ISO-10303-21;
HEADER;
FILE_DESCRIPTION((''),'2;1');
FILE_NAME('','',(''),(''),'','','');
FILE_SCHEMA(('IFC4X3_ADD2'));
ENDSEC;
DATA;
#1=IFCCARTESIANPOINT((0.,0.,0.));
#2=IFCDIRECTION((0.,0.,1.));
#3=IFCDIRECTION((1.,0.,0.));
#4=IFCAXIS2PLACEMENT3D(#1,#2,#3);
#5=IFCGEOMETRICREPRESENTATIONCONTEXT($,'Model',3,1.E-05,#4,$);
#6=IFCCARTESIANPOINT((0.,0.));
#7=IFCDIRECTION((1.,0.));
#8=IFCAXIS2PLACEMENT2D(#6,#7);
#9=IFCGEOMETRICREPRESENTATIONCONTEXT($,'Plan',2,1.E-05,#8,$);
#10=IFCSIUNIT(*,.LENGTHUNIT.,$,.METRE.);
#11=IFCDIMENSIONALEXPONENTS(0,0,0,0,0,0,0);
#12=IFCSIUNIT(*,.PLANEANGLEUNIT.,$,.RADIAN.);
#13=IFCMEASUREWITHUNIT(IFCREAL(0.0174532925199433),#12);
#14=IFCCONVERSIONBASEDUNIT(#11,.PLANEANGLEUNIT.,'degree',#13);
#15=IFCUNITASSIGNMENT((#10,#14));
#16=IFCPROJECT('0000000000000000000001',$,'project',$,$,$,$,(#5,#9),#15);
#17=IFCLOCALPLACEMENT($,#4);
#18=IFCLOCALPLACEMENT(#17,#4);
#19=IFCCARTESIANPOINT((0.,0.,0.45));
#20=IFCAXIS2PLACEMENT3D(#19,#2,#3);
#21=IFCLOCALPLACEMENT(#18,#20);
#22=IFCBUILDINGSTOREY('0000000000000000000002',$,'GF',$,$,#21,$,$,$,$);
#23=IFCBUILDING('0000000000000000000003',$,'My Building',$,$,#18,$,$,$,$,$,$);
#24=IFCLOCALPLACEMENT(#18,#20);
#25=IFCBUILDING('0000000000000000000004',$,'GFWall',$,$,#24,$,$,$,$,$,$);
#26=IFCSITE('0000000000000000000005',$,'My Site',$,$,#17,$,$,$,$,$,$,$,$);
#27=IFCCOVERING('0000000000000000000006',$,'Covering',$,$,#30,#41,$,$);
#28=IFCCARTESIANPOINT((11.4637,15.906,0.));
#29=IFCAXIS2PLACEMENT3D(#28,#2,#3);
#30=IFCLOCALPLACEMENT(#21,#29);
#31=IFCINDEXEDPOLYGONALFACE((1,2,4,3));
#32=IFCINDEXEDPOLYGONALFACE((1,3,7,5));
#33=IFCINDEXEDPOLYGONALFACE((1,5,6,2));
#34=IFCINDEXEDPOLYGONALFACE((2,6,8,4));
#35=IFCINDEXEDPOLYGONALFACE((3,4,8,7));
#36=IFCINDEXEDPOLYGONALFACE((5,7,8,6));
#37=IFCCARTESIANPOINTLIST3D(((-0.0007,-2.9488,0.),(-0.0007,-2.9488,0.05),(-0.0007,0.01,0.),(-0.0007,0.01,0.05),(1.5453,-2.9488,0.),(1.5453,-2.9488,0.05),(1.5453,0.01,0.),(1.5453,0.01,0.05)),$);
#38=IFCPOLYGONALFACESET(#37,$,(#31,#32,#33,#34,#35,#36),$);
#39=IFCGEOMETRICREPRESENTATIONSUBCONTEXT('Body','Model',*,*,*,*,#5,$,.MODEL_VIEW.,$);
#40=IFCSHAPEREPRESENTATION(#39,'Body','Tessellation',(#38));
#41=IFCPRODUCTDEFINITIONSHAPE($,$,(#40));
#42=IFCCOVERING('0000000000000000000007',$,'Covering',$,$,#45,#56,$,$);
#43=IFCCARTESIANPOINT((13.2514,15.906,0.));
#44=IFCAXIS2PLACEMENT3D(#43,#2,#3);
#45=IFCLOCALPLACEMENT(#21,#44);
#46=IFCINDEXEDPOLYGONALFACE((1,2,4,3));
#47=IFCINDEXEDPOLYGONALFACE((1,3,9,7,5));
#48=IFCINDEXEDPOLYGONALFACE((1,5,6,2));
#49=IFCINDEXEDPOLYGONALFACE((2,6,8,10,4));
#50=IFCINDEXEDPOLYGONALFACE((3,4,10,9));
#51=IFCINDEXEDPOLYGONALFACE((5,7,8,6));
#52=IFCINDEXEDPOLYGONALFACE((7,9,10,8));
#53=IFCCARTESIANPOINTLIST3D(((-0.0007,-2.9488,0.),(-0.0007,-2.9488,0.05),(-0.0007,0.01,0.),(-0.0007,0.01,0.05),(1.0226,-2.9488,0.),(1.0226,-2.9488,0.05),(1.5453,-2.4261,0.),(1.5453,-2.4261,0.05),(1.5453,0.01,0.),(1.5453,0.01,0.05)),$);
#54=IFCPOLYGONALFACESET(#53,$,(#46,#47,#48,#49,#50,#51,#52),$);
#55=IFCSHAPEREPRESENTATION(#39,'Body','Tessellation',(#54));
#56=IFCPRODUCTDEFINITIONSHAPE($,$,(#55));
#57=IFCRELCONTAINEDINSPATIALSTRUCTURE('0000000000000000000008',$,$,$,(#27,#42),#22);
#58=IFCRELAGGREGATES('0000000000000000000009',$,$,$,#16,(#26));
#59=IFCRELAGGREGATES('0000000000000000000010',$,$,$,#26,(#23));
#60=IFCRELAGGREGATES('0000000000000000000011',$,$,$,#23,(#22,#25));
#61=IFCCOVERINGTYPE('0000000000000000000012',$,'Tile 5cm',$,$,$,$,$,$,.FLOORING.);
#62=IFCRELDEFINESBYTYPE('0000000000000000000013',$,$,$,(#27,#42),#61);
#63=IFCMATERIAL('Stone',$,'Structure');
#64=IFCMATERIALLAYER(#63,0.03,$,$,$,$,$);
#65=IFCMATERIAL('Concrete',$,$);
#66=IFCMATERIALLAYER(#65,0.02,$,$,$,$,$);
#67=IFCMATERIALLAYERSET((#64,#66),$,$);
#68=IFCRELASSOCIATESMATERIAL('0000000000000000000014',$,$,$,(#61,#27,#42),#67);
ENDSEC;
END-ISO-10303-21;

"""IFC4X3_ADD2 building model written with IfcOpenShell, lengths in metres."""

from ifc_helpers import new_model, entity, si_unit, converted_unit, frame, origin_with_axes, origin_2d_with_axis, place, context, subcontext, project, spatial, indexed_curve, outline, extrude, material, layer, layer_set, layer_usage, type_object, element, save


model = new_model("IFC4X3_ADD2")

# Units and contexts
model_context = context("Model", 3, precision=1e-05, world=origin_with_axes())
plan_context = context("Plan", 2, precision=1e-05, world=origin_2d_with_axis())
body_context_1 = subcontext(model_context, "Body", "Model", "MODEL_VIEW")
ifc_project = project(units=[si_unit("LENGTHUNIT", "METRE"), converted_unit("PLANEANGLEUNIT", "degree", entity("IfcReal", 0.0174532925199433), si_unit("PLANEANGLEUNIT", "RADIAN"), dimensions=[0, 0, 0, 0, 0, 0, 0])], contexts=[model_context, plan_context])

# Site, building, storey
site_placement = place(None, origin_with_axes())
site = spatial("IfcSite", under=ifc_project, at=site_placement, Name="My Site")
building_1_placement = place(site_placement, origin_with_axes())
building_1 = spatial("IfcBuilding", under=site, at=building_1_placement, Name="My Building")
storey_placement = place(building_1_placement, frame((0.0, 0.0, 0.45), z_axis=(0.0, 0.0, 1.0), x_axis=(1.0, 0.0, 0.0)))
storey = spatial("IfcBuildingStorey", under=building_1, at=storey_placement, Name="GF")

# Shared definitions
building_2_placement = place(building_1_placement, frame((0.0, 0.0, 0.45), z_axis=(0.0, 0.0, 1.0), x_axis=(1.0, 0.0, 0.0)))
building_2 = spatial("IfcBuilding", under=building_1, at=building_2_placement, Name="GFWall")

# Coverings
ifc_material_1 = material(Name="Stone", Category="Structure")
ifc_layer_1 = layer(ifc_material_1, 0.03)
ifc_material_2 = material(Name="Concrete")
ifc_layer_2 = layer(ifc_material_2, 0.02)
ifc_layer_set_1 = layer_set([ifc_layer_1, ifc_layer_2])
ifc_layer_usage_1 = layer_usage(ifc_layer_set_1, "AXIS3", "POSITIVE", 0.0)
covering_type = type_object("IfcCoveringType", Name="Tile 5cm", PredefinedType="FLOORING", material=ifc_layer_set_1)
covering_1_placement = place(storey_placement, frame((11.4637, 15.906, 0.0), z_axis=(0.0, 0.0, 1.0), x_axis=(1.0, 0.0, 0.0)))
element("IfcCovering", 1, at=covering_1_placement, inside=storey, type_object=covering_type, material=ifc_layer_usage_1, Name="Covering", context=body_context_1, shape_type="SweptSolid", body=[
    extrude(outline(indexed_curve([(-0.0007, -2.9488), (1.5453, -2.9488), (1.5453, 0.01), (-0.0007, 0.01), (-0.0007, -2.9488)])), None, (0.0, 0.0, 1.0), 0.05),
])
ifc_layer_usage_2 = layer_usage(ifc_layer_set_1, "AXIS3", "POSITIVE", 0.0)
covering_2_placement = place(storey_placement, frame((13.2514, 15.906, 0.0), z_axis=(0.0, 0.0, 1.0), x_axis=(1.0, 0.0, 0.0)))
element("IfcCovering", 2, at=covering_2_placement, inside=storey, type_object=covering_type, material=ifc_layer_usage_2, Name="Covering", context=body_context_1, shape_type="SweptSolid", body=[
    extrude(outline(indexed_curve([(1.0226, -2.9488), (-0.0007, -2.9488), (-0.0007, 0.01), (1.5453, 0.01), (1.5453, -2.4261), (1.0226, -2.9488)])), None, (0.0, 0.0, 1.0), 0.05),
])

save(model, "model.ifc")
